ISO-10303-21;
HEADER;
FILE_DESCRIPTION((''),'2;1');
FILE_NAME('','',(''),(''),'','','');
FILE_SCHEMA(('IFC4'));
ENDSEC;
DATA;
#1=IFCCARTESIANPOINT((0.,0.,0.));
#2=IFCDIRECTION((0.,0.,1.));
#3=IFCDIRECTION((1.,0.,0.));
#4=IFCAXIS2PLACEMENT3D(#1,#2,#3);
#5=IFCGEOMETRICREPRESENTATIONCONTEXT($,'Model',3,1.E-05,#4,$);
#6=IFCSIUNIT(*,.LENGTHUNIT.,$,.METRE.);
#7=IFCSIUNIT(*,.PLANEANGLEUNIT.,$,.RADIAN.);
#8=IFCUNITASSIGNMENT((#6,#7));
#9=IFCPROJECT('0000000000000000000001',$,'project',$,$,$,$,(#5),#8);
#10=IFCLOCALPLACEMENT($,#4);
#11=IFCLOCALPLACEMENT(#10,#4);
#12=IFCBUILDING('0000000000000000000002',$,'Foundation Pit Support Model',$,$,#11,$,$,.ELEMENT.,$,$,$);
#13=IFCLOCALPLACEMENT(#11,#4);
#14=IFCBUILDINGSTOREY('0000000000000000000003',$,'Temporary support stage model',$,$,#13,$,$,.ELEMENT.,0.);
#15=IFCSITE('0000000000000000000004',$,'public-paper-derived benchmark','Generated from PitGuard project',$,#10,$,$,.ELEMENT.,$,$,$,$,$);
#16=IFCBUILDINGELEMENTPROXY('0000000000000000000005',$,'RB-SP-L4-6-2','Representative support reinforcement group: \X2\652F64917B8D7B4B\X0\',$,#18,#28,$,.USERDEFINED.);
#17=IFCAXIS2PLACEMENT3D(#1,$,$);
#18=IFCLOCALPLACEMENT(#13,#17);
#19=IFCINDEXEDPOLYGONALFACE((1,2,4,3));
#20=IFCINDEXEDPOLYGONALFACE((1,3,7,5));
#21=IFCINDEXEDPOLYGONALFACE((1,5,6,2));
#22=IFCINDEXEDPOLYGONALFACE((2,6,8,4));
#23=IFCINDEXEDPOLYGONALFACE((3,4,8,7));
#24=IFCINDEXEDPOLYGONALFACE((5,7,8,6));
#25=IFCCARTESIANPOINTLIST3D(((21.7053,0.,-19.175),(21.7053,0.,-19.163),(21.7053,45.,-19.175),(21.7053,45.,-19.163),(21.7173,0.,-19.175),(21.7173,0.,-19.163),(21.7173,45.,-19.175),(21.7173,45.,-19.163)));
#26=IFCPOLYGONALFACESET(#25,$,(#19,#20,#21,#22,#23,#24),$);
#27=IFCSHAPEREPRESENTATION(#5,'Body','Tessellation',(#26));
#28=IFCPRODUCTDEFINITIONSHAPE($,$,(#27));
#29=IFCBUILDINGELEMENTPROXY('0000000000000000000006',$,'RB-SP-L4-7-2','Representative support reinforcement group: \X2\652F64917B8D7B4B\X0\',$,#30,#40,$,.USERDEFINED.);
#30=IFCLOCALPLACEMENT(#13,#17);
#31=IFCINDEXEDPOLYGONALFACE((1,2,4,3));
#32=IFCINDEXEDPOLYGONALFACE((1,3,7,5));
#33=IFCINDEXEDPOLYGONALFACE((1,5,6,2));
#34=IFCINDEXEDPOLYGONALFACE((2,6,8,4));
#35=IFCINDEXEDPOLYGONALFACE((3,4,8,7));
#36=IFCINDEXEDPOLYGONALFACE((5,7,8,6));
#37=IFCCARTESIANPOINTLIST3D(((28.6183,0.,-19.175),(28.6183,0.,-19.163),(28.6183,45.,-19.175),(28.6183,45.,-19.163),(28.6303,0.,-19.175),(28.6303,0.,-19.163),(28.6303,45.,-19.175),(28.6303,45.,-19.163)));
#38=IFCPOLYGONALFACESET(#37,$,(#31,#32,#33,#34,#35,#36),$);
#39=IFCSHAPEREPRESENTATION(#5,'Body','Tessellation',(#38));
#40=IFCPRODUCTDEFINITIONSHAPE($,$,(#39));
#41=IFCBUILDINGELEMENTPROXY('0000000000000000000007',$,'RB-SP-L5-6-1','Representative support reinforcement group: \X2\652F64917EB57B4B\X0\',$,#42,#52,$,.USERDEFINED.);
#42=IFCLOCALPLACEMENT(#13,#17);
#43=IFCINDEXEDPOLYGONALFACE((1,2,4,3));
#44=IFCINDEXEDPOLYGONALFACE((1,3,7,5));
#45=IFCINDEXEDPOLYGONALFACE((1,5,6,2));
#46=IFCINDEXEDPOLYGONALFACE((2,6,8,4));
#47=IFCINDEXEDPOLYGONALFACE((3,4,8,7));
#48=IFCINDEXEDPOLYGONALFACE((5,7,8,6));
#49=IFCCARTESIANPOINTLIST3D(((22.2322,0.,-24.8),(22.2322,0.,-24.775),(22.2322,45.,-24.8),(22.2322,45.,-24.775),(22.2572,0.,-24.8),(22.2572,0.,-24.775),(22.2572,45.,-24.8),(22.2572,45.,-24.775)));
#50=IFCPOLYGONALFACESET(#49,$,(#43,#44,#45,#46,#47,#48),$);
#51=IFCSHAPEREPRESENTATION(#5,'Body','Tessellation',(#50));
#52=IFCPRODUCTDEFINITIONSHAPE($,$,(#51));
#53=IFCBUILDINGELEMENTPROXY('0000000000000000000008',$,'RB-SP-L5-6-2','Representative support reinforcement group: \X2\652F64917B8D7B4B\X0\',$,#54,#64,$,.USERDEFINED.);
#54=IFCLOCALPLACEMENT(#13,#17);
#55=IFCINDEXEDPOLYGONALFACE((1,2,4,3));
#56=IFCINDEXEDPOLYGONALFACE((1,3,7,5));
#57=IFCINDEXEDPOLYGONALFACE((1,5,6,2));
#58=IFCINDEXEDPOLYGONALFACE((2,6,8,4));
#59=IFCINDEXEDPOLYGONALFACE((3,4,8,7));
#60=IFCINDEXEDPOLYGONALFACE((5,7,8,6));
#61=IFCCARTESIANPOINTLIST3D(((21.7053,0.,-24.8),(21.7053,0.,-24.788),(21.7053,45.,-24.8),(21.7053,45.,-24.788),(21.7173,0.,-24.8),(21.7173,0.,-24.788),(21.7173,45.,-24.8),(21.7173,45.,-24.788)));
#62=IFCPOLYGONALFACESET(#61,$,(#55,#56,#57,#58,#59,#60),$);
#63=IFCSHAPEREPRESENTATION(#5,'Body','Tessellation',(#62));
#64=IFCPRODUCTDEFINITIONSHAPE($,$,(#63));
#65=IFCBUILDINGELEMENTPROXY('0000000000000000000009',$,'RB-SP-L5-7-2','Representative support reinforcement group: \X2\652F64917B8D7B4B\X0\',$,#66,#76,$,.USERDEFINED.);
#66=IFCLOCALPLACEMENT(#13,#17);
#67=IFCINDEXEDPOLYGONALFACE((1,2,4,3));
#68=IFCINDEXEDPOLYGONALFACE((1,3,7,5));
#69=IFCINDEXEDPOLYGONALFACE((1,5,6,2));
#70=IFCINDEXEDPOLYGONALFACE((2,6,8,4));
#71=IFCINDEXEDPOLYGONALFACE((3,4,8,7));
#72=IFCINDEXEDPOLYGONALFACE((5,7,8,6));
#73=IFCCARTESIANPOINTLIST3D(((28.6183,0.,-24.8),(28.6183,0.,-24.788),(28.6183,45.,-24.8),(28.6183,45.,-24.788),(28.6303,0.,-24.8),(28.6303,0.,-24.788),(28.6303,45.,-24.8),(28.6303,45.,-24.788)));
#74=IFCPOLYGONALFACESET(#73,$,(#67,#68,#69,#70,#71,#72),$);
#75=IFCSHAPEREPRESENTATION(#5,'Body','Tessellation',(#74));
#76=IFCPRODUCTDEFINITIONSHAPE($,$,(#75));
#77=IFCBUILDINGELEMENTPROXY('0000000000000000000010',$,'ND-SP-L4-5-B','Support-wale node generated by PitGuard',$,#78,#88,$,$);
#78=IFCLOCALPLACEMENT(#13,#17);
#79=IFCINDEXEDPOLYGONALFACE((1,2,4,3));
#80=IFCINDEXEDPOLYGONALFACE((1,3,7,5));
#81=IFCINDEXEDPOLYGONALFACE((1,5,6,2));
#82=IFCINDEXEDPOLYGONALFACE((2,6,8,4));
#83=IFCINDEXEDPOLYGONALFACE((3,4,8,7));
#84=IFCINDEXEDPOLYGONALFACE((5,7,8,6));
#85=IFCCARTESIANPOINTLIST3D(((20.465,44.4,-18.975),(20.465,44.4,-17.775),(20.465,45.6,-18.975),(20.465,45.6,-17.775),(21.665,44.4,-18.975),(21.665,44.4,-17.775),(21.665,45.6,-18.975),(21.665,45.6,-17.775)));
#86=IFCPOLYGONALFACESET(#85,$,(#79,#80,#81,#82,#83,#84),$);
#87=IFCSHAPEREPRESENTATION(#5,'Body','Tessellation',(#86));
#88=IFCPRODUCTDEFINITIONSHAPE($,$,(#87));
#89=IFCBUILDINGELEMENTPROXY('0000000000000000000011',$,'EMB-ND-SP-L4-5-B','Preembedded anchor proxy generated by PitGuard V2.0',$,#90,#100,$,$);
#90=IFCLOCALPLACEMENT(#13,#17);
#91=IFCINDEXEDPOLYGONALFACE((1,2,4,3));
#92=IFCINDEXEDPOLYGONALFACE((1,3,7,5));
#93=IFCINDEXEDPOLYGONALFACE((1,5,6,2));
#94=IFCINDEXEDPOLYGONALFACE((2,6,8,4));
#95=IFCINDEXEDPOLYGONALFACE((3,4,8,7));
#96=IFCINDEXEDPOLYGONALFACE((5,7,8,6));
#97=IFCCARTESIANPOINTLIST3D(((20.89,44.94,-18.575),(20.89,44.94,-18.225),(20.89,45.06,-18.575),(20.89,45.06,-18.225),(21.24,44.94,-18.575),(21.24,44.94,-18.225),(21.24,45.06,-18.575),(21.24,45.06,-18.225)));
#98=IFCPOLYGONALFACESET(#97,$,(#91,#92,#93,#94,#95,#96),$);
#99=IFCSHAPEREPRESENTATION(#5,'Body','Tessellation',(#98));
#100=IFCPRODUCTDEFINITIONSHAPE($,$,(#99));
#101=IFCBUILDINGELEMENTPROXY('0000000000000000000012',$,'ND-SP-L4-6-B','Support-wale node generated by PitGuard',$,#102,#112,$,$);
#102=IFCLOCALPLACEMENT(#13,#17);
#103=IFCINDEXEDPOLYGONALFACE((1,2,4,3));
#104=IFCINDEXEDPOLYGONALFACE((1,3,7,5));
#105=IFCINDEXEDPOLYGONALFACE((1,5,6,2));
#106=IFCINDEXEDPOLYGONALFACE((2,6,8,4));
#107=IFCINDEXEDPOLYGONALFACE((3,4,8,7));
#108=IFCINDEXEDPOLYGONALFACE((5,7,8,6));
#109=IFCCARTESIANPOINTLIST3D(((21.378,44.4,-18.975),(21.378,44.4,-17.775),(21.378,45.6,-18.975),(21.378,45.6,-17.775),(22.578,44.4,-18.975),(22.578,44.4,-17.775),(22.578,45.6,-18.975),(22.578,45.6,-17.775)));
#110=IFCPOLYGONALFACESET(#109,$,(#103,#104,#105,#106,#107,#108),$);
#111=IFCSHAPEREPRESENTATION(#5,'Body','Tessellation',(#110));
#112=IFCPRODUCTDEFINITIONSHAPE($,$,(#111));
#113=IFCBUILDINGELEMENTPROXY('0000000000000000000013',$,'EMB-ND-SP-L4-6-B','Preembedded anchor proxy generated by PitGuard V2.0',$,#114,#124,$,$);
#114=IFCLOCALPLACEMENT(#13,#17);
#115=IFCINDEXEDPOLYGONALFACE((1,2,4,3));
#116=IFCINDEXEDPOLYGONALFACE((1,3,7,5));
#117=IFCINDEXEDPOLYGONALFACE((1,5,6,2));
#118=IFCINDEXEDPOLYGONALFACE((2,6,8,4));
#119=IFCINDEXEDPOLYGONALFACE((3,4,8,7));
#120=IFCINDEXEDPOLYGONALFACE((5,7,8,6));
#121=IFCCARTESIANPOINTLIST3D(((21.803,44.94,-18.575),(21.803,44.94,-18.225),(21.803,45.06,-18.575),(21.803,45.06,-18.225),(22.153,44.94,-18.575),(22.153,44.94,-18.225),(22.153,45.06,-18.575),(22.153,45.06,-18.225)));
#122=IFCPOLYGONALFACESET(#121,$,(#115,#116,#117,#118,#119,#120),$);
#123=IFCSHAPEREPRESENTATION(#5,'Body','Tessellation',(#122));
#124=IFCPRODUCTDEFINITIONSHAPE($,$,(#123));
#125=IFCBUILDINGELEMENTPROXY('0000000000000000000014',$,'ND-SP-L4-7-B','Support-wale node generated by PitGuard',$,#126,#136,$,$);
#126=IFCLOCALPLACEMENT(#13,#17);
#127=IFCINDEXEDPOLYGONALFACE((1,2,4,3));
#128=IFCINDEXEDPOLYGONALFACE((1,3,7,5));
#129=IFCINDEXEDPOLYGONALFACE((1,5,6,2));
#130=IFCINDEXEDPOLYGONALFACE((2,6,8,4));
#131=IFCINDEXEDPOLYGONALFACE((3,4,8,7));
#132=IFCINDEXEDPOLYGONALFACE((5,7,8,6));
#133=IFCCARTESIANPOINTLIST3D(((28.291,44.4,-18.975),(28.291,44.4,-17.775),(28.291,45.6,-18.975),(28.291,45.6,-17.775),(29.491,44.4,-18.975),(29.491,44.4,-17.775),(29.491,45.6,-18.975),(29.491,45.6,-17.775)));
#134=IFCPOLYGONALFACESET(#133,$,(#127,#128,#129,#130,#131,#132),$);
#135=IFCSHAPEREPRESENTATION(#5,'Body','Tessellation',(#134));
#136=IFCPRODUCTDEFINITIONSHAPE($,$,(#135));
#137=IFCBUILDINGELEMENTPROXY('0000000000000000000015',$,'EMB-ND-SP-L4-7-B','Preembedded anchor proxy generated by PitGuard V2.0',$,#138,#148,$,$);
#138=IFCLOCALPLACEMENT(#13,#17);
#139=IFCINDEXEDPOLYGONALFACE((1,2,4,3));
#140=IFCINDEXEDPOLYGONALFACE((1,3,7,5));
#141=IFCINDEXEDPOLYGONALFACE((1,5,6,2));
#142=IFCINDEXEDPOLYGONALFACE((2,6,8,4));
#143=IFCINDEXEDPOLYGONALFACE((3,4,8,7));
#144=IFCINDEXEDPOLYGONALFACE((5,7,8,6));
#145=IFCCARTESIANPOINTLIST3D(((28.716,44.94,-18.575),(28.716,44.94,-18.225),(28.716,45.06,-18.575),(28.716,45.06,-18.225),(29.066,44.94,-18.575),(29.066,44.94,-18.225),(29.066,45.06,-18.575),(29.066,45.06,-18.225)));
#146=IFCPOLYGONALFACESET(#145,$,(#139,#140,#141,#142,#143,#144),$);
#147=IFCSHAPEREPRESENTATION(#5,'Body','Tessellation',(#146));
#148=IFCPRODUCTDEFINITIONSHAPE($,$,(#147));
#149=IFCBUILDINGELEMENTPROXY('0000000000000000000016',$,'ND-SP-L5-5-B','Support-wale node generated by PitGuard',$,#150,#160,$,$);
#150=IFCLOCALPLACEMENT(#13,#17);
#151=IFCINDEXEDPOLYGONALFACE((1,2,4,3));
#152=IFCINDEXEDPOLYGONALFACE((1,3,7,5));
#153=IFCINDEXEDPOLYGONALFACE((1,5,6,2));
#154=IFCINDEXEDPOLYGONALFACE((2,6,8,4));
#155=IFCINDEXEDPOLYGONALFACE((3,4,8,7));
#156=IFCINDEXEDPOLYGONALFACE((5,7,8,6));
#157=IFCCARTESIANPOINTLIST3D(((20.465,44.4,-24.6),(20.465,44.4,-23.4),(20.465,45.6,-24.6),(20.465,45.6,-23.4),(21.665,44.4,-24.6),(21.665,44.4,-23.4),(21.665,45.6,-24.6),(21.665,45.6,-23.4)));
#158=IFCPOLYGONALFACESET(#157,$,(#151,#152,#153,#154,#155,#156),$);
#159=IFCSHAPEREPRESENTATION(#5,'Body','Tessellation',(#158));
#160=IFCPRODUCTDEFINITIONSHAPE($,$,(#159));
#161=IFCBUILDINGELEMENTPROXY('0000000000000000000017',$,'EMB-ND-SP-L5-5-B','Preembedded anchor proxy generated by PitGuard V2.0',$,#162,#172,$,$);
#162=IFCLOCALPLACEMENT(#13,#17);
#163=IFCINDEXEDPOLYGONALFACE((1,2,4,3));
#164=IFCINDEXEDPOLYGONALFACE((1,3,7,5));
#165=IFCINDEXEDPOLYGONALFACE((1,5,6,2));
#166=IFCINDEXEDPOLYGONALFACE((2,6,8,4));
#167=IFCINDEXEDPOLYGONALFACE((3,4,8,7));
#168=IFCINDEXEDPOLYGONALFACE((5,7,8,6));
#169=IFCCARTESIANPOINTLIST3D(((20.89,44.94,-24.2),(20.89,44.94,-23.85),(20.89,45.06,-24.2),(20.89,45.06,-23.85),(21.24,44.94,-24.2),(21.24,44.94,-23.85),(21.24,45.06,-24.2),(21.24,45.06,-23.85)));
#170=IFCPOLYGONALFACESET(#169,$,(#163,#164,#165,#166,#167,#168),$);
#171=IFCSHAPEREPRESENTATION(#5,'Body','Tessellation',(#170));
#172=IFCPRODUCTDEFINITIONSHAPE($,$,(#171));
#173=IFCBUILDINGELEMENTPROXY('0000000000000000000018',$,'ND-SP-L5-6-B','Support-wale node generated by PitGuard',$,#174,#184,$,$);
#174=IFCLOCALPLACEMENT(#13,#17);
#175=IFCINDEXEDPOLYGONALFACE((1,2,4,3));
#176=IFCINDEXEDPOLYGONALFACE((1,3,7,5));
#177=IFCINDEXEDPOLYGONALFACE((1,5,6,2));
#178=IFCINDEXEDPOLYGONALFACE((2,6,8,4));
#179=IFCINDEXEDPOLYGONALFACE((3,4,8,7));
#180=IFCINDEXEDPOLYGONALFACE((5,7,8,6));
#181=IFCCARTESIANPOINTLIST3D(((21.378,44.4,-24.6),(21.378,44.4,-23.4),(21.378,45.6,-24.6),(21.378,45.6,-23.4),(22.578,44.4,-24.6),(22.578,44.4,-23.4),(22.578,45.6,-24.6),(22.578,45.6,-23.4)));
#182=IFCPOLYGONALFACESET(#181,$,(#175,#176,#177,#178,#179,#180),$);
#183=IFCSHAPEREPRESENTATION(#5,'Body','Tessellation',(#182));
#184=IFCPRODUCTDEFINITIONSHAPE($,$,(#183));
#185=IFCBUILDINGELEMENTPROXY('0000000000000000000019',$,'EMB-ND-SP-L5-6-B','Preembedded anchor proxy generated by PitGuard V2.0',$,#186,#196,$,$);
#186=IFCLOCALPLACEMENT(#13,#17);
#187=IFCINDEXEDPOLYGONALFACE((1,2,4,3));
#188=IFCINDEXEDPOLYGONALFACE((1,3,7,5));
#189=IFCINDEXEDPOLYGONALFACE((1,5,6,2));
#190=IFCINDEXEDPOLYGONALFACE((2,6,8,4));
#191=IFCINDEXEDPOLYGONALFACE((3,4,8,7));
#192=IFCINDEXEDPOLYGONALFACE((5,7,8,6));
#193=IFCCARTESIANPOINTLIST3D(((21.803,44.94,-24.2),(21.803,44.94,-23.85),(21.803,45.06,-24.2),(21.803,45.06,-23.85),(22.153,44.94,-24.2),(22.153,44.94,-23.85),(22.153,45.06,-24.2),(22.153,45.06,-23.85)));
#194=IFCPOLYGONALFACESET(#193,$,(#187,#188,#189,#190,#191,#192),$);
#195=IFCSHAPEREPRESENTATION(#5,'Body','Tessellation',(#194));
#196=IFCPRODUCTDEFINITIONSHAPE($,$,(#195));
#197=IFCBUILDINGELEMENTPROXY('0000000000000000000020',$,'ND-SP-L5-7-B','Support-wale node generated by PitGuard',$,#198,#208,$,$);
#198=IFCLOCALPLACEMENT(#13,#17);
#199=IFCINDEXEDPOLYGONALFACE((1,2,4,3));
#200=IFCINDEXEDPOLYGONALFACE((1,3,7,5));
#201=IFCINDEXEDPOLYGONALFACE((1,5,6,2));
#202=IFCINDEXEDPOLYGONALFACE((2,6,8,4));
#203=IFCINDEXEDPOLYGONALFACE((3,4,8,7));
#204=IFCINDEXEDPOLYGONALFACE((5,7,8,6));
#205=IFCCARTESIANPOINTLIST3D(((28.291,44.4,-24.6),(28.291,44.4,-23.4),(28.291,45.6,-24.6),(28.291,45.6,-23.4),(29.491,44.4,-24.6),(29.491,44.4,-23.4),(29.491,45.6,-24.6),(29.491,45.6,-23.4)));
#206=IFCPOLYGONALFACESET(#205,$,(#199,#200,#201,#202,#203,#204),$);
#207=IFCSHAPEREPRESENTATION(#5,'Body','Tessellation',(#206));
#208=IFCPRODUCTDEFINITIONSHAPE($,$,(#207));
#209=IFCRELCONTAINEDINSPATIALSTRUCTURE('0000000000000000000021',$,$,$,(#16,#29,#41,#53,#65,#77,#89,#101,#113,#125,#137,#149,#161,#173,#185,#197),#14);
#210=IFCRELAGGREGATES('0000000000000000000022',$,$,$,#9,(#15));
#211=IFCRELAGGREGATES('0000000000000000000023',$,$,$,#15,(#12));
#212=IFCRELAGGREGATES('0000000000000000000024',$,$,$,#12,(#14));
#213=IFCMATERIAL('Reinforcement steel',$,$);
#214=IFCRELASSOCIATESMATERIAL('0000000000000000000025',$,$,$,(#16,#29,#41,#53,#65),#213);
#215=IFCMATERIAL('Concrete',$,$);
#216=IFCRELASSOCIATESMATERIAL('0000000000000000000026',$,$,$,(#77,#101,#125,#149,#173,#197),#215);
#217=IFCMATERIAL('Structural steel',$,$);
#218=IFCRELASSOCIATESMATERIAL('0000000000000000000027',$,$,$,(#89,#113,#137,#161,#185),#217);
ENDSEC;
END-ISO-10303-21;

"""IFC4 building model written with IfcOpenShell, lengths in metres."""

from ifc_helpers import new_model, si_unit, frame, origin_with_axes, origin_2d, place, context, project, spatial, rectangle, extrude, material, element, save


model = new_model("IFC4")

# Units and contexts
model_context = context("Model", 3, precision=1e-05, world=origin_with_axes())
ifc_project = project(units=[si_unit("LENGTHUNIT", "METRE"), si_unit("PLANEANGLEUNIT", "RADIAN")], contexts=[model_context])

# Site, building, storey
site_placement = place(None, origin_with_axes())
site = spatial("IfcSite", under=ifc_project, at=site_placement, Name="public-paper-derived benchmark", Description="Generated from PitGuard project", CompositionType="ELEMENT")
building_placement = place(site_placement, origin_with_axes())
building = spatial("IfcBuilding", under=site, at=building_placement, Name="Foundation Pit Support Model", CompositionType="ELEMENT")
storey_placement = place(building_placement, origin_with_axes())
storey = spatial("IfcBuildingStorey", under=building, at=storey_placement, Name="Temporary support stage model", CompositionType="ELEMENT", Elevation=0.0)

# Shared definitions
ifc_material_1 = material(Name="Structural steel")

# Shared definitions
ifc_material_2 = material(Name="Concrete")

# Building element proxies
ifc_material_3 = material(Name="Reinforcement steel")
for number, where, z_axis, x_axis, name in (
    (1, (21.7113, 22.5, -19.175), (0.0, 0.0, 1.0), (0.0, 1.0, 0.0), "RB-SP-L4-6-2"),
    (2, (28.6243, 22.5, -19.175), (0.0, 0.0, 1.0), (0.0, 1.0, 0.0), "RB-SP-L4-7-2"),
):
    element("IfcBuildingElementProxy", number, at=place(storey_placement, frame(where, z_axis=z_axis, x_axis=x_axis)), inside=storey, material=ifc_material_3, Name=name, Description="Representative support reinforcement group: 支撑箍筋", PredefinedType="USERDEFINED", context=model_context, shape_type="SweptSolid", body=[
        extrude(rectangle(XDim=45.0, YDim=0.012, at=origin_2d()), origin_with_axes(), (0.0, 0.0, 1.0), 0.012),
    ])
proxy_1_placement = place(storey_placement, frame((22.2447, 22.5, -24.8), z_axis=(0.0, 0.0, 1.0), x_axis=(0.0, 1.0, 0.0)))
element("IfcBuildingElementProxy", 3, at=proxy_1_placement, inside=storey, material=ifc_material_3, Name="RB-SP-L5-6-1", Description="Representative support reinforcement group: 支撑纵筋", PredefinedType="USERDEFINED", context=model_context, shape_type="SweptSolid", body=[
    extrude(rectangle(XDim=45.0, YDim=0.025, at=origin_2d()), origin_with_axes(), (0.0, 0.0, 1.0), 0.025),
])
for number, where, z_axis, x_axis, name in (
    (4, (21.7113, 22.5, -24.8), (0.0, 0.0, 1.0), (0.0, 1.0, 0.0), "RB-SP-L5-6-2"),
    (5, (28.6243, 22.5, -24.8), (0.0, 0.0, 1.0), (0.0, 1.0, 0.0), "RB-SP-L5-7-2"),
):
    element("IfcBuildingElementProxy", number, at=place(storey_placement, frame(where, z_axis=z_axis, x_axis=x_axis)), inside=storey, material=ifc_material_3, Name=name, Description="Representative support reinforcement group: 支撑箍筋", PredefinedType="USERDEFINED", context=model_context, shape_type="SweptSolid", body=[
        extrude(rectangle(XDim=45.0, YDim=0.012, at=origin_2d()), origin_with_axes(), (0.0, 0.0, 1.0), 0.012),
    ])
proxy_2_placement = place(storey_placement, frame((21.065, 45.0, -18.975), z_axis=(0.0, 0.0, 1.0), x_axis=(1.0, 0.0, 0.0)))
element("IfcBuildingElementProxy", 6, at=proxy_2_placement, inside=storey, material=ifc_material_2, Name="ND-SP-L4-5-B", Description="Support-wale node generated by PitGuard", context=model_context, shape_type="SweptSolid", body=[
    extrude(rectangle(XDim=1.2, YDim=1.2, at=origin_2d()), origin_with_axes(), (0.0, 0.0, 1.0), 1.2),
])
proxy_3_placement = place(storey_placement, frame((21.065, 45.0, -18.575), z_axis=(0.0, 0.0, 1.0), x_axis=(1.0, 0.0, 0.0)))
element("IfcBuildingElementProxy", 7, at=proxy_3_placement, inside=storey, material=ifc_material_1, Name="EMB-ND-SP-L4-5-B", Description="Preembedded anchor proxy generated by PitGuard V2.0", context=model_context, shape_type="SweptSolid", body=[
    extrude(rectangle(XDim=0.35, YDim=0.12, at=origin_2d()), origin_with_axes(), (0.0, 0.0, 1.0), 0.35),
])
proxy_4_placement = place(storey_placement, frame((21.978, 45.0, -18.975), z_axis=(0.0, 0.0, 1.0), x_axis=(1.0, 0.0, 0.0)))
element("IfcBuildingElementProxy", 8, at=proxy_4_placement, inside=storey, material=ifc_material_2, Name="ND-SP-L4-6-B", Description="Support-wale node generated by PitGuard", context=model_context, shape_type="SweptSolid", body=[
    extrude(rectangle(XDim=1.2, YDim=1.2, at=origin_2d()), origin_with_axes(), (0.0, 0.0, 1.0), 1.2),
])
proxy_5_placement = place(storey_placement, frame((21.978, 45.0, -18.575), z_axis=(0.0, 0.0, 1.0), x_axis=(1.0, 0.0, 0.0)))
element("IfcBuildingElementProxy", 9, at=proxy_5_placement, inside=storey, material=ifc_material_1, Name="EMB-ND-SP-L4-6-B", Description="Preembedded anchor proxy generated by PitGuard V2.0", context=model_context, shape_type="SweptSolid", body=[
    extrude(rectangle(XDim=0.35, YDim=0.12, at=origin_2d()), origin_with_axes(), (0.0, 0.0, 1.0), 0.35),
])
proxy_6_placement = place(storey_placement, frame((28.891, 45.0, -18.975), z_axis=(0.0, 0.0, 1.0), x_axis=(1.0, 0.0, 0.0)))
element("IfcBuildingElementProxy", 10, at=proxy_6_placement, inside=storey, material=ifc_material_2, Name="ND-SP-L4-7-B", Description="Support-wale node generated by PitGuard", context=model_context, shape_type="SweptSolid", body=[
    extrude(rectangle(XDim=1.2, YDim=1.2, at=origin_2d()), origin_with_axes(), (0.0, 0.0, 1.0), 1.2),
])
proxy_7_placement = place(storey_placement, frame((28.891, 45.0, -18.575), z_axis=(0.0, 0.0, 1.0), x_axis=(1.0, 0.0, 0.0)))
element("IfcBuildingElementProxy", 11, at=proxy_7_placement, inside=storey, material=ifc_material_1, Name="EMB-ND-SP-L4-7-B", Description="Preembedded anchor proxy generated by PitGuard V2.0", context=model_context, shape_type="SweptSolid", body=[
    extrude(rectangle(XDim=0.35, YDim=0.12, at=origin_2d()), origin_with_axes(), (0.0, 0.0, 1.0), 0.35),
])
proxy_8_placement = place(storey_placement, frame((21.065, 45.0, -24.6), z_axis=(0.0, 0.0, 1.0), x_axis=(1.0, 0.0, 0.0)))
element("IfcBuildingElementProxy", 12, at=proxy_8_placement, inside=storey, material=ifc_material_2, Name="ND-SP-L5-5-B", Description="Support-wale node generated by PitGuard", context=model_context, shape_type="SweptSolid", body=[
    extrude(rectangle(XDim=1.2, YDim=1.2, at=origin_2d()), origin_with_axes(), (0.0, 0.0, 1.0), 1.2),
])
proxy_9_placement = place(storey_placement, frame((21.065, 45.0, -24.2), z_axis=(0.0, 0.0, 1.0), x_axis=(1.0, 0.0, 0.0)))
element("IfcBuildingElementProxy", 13, at=proxy_9_placement, inside=storey, material=ifc_material_1, Name="EMB-ND-SP-L5-5-B", Description="Preembedded anchor proxy generated by PitGuard V2.0", context=model_context, shape_type="SweptSolid", body=[
    extrude(rectangle(XDim=0.35, YDim=0.12, at=origin_2d()), origin_with_axes(), (0.0, 0.0, 1.0), 0.35),
])
proxy_10_placement = place(storey_placement, frame((21.978, 45.0, -24.6), z_axis=(0.0, 0.0, 1.0), x_axis=(1.0, 0.0, 0.0)))
element("IfcBuildingElementProxy", 14, at=proxy_10_placement, inside=storey, material=ifc_material_2, Name="ND-SP-L5-6-B", Description="Support-wale node generated by PitGuard", context=model_context, shape_type="SweptSolid", body=[
    extrude(rectangle(XDim=1.2, YDim=1.2, at=origin_2d()), origin_with_axes(), (0.0, 0.0, 1.0), 1.2),
])
proxy_11_placement = place(storey_placement, frame((21.978, 45.0, -24.2), z_axis=(0.0, 0.0, 1.0), x_axis=(1.0, 0.0, 0.0)))
element("IfcBuildingElementProxy", 15, at=proxy_11_placement, inside=storey, material=ifc_material_1, Name="EMB-ND-SP-L5-6-B", Description="Preembedded anchor proxy generated by PitGuard V2.0", context=model_context, shape_type="SweptSolid", body=[
    extrude(rectangle(XDim=0.35, YDim=0.12, at=origin_2d()), origin_with_axes(), (0.0, 0.0, 1.0), 0.35),
])
proxy_12_placement = place(storey_placement, frame((28.891, 45.0, -24.6), z_axis=(0.0, 0.0, 1.0), x_axis=(1.0, 0.0, 0.0)))
element("IfcBuildingElementProxy", 16, at=proxy_12_placement, inside=storey, material=ifc_material_2, Name="ND-SP-L5-7-B", Description="Support-wale node generated by PitGuard", context=model_context, shape_type="SweptSolid", body=[
    extrude(rectangle(XDim=1.2, YDim=1.2, at=origin_2d()), origin_with_axes(), (0.0, 0.0, 1.0), 1.2),
])

save(model, "model.ifc")
